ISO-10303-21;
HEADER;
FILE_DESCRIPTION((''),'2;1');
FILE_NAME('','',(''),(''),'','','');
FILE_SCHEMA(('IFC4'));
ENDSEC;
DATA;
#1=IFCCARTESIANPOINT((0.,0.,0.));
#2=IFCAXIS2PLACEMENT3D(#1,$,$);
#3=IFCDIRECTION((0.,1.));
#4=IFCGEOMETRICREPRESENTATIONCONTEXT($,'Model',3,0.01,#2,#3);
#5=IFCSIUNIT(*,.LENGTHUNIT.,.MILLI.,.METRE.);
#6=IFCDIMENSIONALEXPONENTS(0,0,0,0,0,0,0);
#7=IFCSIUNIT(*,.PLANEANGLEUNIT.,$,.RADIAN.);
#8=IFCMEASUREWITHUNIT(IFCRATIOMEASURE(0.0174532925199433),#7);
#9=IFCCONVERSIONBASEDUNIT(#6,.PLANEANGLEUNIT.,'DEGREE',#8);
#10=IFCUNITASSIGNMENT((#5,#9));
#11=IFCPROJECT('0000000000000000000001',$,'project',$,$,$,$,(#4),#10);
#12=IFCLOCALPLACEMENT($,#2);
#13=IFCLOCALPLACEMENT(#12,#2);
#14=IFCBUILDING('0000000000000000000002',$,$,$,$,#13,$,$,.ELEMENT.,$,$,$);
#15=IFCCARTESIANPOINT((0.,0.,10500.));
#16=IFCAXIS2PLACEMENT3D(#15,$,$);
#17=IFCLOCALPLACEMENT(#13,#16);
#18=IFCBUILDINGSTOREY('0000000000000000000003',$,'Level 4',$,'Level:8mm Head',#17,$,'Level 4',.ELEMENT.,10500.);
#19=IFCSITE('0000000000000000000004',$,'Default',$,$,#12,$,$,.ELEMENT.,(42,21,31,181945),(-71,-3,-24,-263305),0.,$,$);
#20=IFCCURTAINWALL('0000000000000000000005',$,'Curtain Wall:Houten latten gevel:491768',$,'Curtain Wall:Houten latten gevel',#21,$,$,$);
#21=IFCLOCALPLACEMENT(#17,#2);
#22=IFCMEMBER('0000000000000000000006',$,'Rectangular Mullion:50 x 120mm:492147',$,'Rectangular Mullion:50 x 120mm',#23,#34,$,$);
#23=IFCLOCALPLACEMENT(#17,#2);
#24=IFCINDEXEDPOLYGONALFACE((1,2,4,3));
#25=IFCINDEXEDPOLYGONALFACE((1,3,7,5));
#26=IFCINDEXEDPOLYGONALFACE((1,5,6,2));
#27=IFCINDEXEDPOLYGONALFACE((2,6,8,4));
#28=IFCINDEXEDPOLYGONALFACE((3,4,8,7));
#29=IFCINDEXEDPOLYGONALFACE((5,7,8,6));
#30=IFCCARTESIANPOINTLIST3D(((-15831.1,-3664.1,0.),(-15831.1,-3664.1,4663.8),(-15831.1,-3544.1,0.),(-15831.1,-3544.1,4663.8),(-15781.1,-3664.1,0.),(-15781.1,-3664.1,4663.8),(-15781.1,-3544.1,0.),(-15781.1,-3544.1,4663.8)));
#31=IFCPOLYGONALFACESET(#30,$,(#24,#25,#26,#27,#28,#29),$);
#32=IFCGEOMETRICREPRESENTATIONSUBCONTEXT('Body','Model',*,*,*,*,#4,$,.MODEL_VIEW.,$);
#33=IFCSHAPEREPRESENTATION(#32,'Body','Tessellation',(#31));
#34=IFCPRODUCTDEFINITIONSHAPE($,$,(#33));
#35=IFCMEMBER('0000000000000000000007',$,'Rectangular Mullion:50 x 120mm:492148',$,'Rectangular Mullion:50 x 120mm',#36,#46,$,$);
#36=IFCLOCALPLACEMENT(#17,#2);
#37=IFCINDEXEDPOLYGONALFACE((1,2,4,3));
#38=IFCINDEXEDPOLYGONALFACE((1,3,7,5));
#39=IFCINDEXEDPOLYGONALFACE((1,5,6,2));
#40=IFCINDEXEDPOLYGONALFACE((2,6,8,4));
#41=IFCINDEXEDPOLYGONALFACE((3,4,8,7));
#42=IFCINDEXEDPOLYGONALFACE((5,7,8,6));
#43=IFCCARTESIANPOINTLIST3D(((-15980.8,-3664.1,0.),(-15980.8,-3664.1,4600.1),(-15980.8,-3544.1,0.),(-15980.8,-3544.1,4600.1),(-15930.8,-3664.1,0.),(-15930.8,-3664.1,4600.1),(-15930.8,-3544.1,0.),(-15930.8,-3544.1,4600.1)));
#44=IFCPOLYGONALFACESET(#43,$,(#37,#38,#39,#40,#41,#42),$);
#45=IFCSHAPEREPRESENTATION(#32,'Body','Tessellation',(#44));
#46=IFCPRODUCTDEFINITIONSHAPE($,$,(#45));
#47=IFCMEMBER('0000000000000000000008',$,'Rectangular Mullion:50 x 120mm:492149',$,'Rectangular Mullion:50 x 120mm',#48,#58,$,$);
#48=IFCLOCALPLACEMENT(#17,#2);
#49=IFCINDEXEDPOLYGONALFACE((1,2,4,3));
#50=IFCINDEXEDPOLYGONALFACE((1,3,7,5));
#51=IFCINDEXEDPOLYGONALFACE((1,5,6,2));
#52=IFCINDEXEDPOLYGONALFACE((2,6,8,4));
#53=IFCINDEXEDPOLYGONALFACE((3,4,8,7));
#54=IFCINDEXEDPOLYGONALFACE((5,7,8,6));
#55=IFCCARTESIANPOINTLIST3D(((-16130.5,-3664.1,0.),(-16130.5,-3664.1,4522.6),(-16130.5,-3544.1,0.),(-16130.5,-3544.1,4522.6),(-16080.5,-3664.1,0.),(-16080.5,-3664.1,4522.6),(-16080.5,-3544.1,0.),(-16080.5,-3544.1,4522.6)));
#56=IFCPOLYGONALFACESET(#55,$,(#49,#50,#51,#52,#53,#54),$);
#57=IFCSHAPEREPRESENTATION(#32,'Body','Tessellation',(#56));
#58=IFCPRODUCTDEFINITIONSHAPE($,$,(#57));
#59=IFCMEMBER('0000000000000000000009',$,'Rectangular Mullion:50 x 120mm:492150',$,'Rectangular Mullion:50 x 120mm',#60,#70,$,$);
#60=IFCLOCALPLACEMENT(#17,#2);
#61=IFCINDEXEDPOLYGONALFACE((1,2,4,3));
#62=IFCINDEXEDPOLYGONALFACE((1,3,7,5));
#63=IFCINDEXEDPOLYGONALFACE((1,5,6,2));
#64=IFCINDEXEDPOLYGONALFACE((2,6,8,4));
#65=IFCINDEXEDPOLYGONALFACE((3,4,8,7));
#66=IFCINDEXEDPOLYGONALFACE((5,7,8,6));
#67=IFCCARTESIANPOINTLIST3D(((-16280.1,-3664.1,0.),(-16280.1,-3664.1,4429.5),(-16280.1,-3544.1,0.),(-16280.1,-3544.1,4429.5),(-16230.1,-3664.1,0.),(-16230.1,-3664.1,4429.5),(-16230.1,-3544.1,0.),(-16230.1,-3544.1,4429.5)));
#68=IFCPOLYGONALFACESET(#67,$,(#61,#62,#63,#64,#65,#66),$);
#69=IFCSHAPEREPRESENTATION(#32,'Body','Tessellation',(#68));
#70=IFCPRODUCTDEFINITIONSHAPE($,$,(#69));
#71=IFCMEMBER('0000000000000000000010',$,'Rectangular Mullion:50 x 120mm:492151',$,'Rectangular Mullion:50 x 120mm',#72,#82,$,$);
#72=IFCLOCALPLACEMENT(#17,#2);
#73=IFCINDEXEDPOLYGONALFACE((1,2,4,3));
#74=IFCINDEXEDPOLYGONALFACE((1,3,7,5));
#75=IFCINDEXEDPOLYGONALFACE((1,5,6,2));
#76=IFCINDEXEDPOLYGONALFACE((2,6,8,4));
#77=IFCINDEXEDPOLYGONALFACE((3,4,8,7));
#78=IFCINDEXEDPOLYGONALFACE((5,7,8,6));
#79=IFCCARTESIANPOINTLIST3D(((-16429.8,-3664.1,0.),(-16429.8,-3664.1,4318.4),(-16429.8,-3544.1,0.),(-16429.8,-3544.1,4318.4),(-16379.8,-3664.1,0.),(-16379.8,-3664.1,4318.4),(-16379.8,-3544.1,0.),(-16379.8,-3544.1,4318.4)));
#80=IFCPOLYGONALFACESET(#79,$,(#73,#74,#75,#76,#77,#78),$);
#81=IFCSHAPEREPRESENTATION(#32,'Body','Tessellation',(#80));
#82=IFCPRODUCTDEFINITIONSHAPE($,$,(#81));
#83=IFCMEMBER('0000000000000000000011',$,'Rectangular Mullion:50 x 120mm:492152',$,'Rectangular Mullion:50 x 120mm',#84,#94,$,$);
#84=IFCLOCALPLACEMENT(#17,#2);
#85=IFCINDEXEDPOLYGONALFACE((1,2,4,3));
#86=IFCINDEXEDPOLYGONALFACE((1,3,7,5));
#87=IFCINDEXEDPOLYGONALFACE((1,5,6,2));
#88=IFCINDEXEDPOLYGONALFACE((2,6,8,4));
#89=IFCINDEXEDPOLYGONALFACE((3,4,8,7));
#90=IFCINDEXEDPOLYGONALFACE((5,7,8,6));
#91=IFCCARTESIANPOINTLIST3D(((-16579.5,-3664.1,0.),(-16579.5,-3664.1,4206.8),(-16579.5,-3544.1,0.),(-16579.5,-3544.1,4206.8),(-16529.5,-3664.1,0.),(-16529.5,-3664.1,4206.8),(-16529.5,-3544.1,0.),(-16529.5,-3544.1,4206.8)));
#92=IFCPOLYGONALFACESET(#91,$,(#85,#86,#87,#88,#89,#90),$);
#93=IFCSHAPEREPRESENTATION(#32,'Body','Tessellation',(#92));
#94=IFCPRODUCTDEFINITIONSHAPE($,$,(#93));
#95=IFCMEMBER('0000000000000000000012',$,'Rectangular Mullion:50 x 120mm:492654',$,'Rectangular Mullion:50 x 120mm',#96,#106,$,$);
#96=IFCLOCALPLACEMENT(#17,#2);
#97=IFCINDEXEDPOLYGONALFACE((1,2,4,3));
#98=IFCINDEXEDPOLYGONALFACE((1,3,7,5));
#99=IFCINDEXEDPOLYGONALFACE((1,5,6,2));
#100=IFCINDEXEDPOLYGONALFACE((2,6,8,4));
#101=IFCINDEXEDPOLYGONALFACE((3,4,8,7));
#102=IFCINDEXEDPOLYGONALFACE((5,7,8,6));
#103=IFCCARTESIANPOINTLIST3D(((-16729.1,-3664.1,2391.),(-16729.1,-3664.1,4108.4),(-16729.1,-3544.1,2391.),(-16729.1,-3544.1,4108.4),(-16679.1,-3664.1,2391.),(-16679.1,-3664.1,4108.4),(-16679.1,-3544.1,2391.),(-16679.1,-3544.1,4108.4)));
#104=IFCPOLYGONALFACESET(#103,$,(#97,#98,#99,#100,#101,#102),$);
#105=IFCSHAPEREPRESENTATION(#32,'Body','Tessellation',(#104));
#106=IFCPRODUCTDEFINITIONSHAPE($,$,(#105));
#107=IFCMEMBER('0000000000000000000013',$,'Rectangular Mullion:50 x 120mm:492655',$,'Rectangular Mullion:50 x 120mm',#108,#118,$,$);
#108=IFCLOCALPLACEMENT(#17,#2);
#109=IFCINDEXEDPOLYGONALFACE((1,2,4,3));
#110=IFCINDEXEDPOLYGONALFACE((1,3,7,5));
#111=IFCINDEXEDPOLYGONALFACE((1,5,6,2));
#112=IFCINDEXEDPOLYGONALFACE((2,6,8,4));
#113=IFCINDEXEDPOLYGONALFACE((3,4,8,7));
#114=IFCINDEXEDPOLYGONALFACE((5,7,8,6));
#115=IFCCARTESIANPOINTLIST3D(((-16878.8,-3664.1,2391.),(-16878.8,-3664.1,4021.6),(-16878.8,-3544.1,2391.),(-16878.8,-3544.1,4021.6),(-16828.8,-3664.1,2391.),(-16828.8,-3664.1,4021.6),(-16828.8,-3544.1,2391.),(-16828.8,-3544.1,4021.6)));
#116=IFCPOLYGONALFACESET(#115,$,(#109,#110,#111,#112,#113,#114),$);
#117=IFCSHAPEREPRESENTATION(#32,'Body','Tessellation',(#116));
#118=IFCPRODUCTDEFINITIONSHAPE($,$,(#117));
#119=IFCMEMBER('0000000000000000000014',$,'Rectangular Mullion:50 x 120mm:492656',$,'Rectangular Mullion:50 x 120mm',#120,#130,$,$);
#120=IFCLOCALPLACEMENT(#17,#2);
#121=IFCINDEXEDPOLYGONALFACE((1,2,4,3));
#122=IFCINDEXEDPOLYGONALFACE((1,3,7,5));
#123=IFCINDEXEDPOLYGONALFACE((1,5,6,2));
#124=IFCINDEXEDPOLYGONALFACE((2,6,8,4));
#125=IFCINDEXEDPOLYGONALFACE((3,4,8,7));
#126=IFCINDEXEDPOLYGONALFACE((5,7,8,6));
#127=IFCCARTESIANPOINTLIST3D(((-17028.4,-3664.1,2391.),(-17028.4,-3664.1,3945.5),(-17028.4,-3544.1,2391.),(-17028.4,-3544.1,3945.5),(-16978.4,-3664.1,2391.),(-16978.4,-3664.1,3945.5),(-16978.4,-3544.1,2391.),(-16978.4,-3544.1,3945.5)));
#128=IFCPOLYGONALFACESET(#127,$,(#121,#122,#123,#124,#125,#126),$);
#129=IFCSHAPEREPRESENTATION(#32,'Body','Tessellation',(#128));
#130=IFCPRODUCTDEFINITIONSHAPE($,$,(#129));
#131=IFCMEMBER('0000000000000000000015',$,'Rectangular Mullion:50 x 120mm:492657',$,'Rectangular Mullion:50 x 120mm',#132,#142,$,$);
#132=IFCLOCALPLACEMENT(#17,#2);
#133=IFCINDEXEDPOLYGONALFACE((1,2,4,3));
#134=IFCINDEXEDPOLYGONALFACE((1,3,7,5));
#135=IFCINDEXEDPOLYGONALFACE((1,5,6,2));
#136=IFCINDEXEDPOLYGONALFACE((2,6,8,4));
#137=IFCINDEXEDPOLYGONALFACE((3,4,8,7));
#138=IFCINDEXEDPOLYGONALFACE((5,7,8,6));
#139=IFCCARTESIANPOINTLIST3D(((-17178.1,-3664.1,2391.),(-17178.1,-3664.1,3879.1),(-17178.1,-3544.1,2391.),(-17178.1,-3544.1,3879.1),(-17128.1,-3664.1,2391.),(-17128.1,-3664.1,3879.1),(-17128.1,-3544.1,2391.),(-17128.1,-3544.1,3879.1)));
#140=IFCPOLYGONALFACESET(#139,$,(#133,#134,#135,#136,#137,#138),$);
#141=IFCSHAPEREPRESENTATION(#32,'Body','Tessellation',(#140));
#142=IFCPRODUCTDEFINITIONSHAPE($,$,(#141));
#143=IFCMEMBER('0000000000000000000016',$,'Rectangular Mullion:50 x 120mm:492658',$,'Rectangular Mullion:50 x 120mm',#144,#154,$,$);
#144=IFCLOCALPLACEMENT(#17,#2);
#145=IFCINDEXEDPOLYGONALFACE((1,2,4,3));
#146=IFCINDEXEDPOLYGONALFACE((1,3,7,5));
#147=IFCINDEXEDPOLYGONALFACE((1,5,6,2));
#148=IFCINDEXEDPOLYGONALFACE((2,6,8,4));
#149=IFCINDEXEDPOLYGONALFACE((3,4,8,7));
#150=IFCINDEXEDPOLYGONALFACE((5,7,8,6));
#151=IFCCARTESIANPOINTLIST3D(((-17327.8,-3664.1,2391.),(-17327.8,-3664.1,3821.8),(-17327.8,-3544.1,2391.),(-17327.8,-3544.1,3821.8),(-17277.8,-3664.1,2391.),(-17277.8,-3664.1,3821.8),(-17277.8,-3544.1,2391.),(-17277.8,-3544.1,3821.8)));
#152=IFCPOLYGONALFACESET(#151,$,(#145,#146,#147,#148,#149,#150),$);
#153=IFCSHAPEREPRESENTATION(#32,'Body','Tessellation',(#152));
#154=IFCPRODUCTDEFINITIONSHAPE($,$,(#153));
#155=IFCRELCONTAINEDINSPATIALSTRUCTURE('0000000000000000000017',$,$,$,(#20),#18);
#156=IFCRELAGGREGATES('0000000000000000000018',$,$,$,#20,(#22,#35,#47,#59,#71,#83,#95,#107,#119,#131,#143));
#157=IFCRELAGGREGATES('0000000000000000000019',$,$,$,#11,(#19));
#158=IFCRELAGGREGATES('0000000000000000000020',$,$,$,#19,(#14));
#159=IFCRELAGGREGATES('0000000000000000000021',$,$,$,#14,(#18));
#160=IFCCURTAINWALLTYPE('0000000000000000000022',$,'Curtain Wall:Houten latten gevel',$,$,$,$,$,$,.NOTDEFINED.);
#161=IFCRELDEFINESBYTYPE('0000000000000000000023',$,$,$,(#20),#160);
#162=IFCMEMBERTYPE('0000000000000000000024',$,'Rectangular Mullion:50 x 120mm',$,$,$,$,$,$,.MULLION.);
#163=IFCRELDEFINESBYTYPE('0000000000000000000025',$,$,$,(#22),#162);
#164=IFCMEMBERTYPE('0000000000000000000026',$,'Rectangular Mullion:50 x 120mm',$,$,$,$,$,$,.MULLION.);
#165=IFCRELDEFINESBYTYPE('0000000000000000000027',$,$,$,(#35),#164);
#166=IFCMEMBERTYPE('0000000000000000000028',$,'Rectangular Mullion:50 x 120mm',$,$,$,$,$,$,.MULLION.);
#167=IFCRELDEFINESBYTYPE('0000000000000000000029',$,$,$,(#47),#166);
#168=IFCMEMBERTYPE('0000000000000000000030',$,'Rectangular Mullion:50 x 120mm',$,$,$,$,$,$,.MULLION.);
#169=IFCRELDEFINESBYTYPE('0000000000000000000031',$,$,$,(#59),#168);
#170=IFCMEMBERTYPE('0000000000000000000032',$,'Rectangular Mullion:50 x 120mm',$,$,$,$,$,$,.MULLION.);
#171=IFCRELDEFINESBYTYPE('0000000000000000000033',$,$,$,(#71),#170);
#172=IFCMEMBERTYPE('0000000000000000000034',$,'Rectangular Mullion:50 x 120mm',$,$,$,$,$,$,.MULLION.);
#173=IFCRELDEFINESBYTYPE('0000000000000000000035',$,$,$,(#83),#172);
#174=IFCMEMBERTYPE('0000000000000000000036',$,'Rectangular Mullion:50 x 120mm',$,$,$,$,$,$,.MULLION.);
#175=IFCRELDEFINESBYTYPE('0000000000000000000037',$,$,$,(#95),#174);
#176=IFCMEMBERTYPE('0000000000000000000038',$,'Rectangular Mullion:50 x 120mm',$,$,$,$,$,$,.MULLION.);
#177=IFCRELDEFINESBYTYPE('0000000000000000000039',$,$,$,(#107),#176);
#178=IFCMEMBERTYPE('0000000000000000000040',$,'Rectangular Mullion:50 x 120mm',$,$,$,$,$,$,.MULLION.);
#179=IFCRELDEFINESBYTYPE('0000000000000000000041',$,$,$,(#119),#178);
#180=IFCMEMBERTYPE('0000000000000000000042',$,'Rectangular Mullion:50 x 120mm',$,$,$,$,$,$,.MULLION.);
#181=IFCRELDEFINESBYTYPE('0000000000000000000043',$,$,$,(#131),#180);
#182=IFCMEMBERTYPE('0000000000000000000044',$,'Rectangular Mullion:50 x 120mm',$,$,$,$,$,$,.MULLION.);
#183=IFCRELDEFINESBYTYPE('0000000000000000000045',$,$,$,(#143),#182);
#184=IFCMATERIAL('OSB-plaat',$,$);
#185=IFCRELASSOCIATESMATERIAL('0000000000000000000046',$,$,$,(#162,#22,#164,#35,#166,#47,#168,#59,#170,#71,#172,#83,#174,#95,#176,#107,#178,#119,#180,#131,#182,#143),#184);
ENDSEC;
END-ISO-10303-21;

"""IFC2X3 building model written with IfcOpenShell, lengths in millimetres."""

from ifc_helpers import new_model, entity, si_unit, converted_unit, direction, frame, origin, origin_2d_with_axis, place, context, subcontext, project, spatial, rectangle, extrude, source, transform, mapped, material, type_object, type_shapes, element, aggregate, save


model = new_model("IFC2X3")

# Units and contexts
model_context = context("Model", 3, precision=0.01, world=origin(), true_north=direction((0.0, 1.0)))
body_context = subcontext(model_context, "Body", "Model", "MODEL_VIEW")
ifc_project = project(units=[si_unit("LENGTHUNIT", "METRE", prefix="MILLI"), converted_unit("PLANEANGLEUNIT", "DEGREE", entity("IfcRatioMeasure", 0.0174532925199433), si_unit("PLANEANGLEUNIT", "RADIAN"), dimensions=[0, 0, 0, 0, 0, 0, 0])], contexts=[model_context])

# Site, building, storey
site_placement = place(None, frame((0.0, 0.0, 0.0)))
site = spatial("IfcSite", under=ifc_project, at=site_placement, Name="Default", CompositionType="ELEMENT", RefLatitude=(42, 21, 31, 181945), RefLongitude=(-71, -3, -24, -263305), RefElevation=0.0)
building_placement = place(site_placement, origin())
building = spatial("IfcBuilding", under=site, at=building_placement, CompositionType="ELEMENT")
storey_placement = place(building_placement, frame((0.0, 0.0, 10500.0)))
storey = spatial("IfcBuildingStorey", under=building, at=storey_placement, Name="Level 4", ObjectType="Level:8mm Head", LongName="Level 4", CompositionType="ELEMENT", Elevation=10500.0)

# Curtain wall, members
curtain_wall_type = type_object("IfcCurtainWallType", Name="Curtain Wall:Houten latten gevel", PredefinedType="NOTDEFINED")
curtain_wall_placement = place(storey_placement, frame((0.0, 0.0, -10500.0)))
curtain_wall = element("IfcCurtainWall", 1, at=curtain_wall_placement, inside=storey, type_object=curtain_wall_type, Name="Curtain Wall:Houten latten gevel:491768", ObjectType="Curtain Wall:Houten latten gevel")
ifc_material_1 = material(Name="OSB-plaat")
placement = place(building_placement, frame((0.0, 0.0, 7500.0)))
member_type_1 = type_object("IfcMemberType", Name="Rectangular Mullion:50 x 120mm", PredefinedType="MULLION", material=ifc_material_1)
shared_shape_1 = source(origin(), body_context, "Body", "SweptSolid", [
    extrude(rectangle(XDim=120.0, YDim=50.0, at=origin_2d_with_axis()), frame((0.0, 0.0, -4663.8), z_axis=(0.0, 0.0, 1.0), x_axis=(0.0, -1.0, 0.0)), (0.0, 0.0, 1.0), 4663.8),
])
type_shapes(member_type_1, [shared_shape_1])
member_1_placement = place(placement, frame((-15806.1, -3604.1, 3000.0), z_axis=(0.0, 0.0, -1.0), x_axis=(-1.0, 0.0, 0.0)))
member_1 = element("IfcMember", 2, at=member_1_placement, type_object=member_type_1, material=ifc_material_1, Name="Rectangular Mullion:50 x 120mm:492147", ObjectType="Rectangular Mullion:50 x 120mm", context=body_context, shape_type="MappedRepresentation", body=[
    mapped(shared_shape_1, transform((0.0, 0.0, 0.0), scale=1.0)),
])
member_type_2 = type_object("IfcMemberType", Name="Rectangular Mullion:50 x 120mm", PredefinedType="MULLION", material=ifc_material_1)
shared_shape_2 = source(origin(), body_context, "Body", "SweptSolid", [
    extrude(rectangle(XDim=120.0, YDim=50.0, at=origin_2d_with_axis()), frame((0.0, 0.0, -4600.1), z_axis=(0.0, 0.0, 1.0), x_axis=(0.0, -1.0, 0.0)), (0.0, 0.0, 1.0), 4600.1),
])
type_shapes(member_type_2, [shared_shape_2])
member_2_placement = place(placement, frame((-15955.8, -3604.1, 3000.0), z_axis=(0.0, 0.0, -1.0), x_axis=(-1.0, 0.0, 0.0)))
member_2 = element("IfcMember", 3, at=member_2_placement, type_object=member_type_2, material=ifc_material_1, Name="Rectangular Mullion:50 x 120mm:492148", ObjectType="Rectangular Mullion:50 x 120mm", context=body_context, shape_type="MappedRepresentation", body=[
    mapped(shared_shape_2, transform((0.0, 0.0, 0.0), scale=1.0)),
])
member_type_3 = type_object("IfcMemberType", Name="Rectangular Mullion:50 x 120mm", PredefinedType="MULLION", material=ifc_material_1)
shared_shape_3 = source(origin(), body_context, "Body", "SweptSolid", [
    extrude(rectangle(XDim=120.0, YDim=50.0, at=origin_2d_with_axis()), frame((0.0, 0.0, -4522.6), z_axis=(0.0, 0.0, 1.0), x_axis=(0.0, -1.0, 0.0)), (0.0, 0.0, 1.0), 4522.6),
])
type_shapes(member_type_3, [shared_shape_3])
member_3_placement = place(placement, frame((-16105.5, -3604.1, 3000.0), z_axis=(0.0, 0.0, -1.0), x_axis=(-1.0, 0.0, 0.0)))
member_3 = element("IfcMember", 4, at=member_3_placement, type_object=member_type_3, material=ifc_material_1, Name="Rectangular Mullion:50 x 120mm:492149", ObjectType="Rectangular Mullion:50 x 120mm", context=body_context, shape_type="MappedRepresentation", body=[
    mapped(shared_shape_3, transform((0.0, 0.0, 0.0), scale=1.0)),
])
member_type_4 = type_object("IfcMemberType", Name="Rectangular Mullion:50 x 120mm", PredefinedType="MULLION", material=ifc_material_1)
shared_shape_4 = source(origin(), body_context, "Body", "SweptSolid", [
    extrude(rectangle(XDim=120.0, YDim=50.0, at=origin_2d_with_axis()), frame((0.0, 0.0, -4429.5), z_axis=(0.0, 0.0, 1.0), x_axis=(0.0, -1.0, 0.0)), (0.0, 0.0, 1.0), 4429.5),
])
type_shapes(member_type_4, [shared_shape_4])
member_4_placement = place(placement, frame((-16255.1, -3604.1, 3000.0), z_axis=(0.0, 0.0, -1.0), x_axis=(-1.0, 0.0, 0.0)))
member_4 = element("IfcMember", 5, at=member_4_placement, type_object=member_type_4, material=ifc_material_1, Name="Rectangular Mullion:50 x 120mm:492150", ObjectType="Rectangular Mullion:50 x 120mm", context=body_context, shape_type="MappedRepresentation", body=[
    mapped(shared_shape_4, transform((0.0, 0.0, 0.0), scale=1.0)),
])
member_type_5 = type_object("IfcMemberType", Name="Rectangular Mullion:50 x 120mm", PredefinedType="MULLION", material=ifc_material_1)
shared_shape_5 = source(origin(), body_context, "Body", "SweptSolid", [
    extrude(rectangle(XDim=120.0, YDim=50.0, at=origin_2d_with_axis()), frame((0.0, 0.0, -4318.4), z_axis=(0.0, 0.0, 1.0), x_axis=(0.0, -1.0, 0.0)), (0.0, 0.0, 1.0), 4318.4),
])
type_shapes(member_type_5, [shared_shape_5])
member_5_placement = place(placement, frame((-16404.8, -3604.1, 3000.0), z_axis=(0.0, 0.0, -1.0), x_axis=(-1.0, 0.0, 0.0)))
member_5 = element("IfcMember", 6, at=member_5_placement, type_object=member_type_5, material=ifc_material_1, Name="Rectangular Mullion:50 x 120mm:492151", ObjectType="Rectangular Mullion:50 x 120mm", context=body_context, shape_type="MappedRepresentation", body=[
    mapped(shared_shape_5, transform((0.0, 0.0, 0.0), scale=1.0)),
])
member_type_6 = type_object("IfcMemberType", Name="Rectangular Mullion:50 x 120mm", PredefinedType="MULLION", material=ifc_material_1)
shared_shape_6 = source(origin(), body_context, "Body", "SweptSolid", [
    extrude(rectangle(XDim=120.0, YDim=50.0, at=origin_2d_with_axis()), frame((0.0, 0.0, -4206.8), z_axis=(0.0, 0.0, 1.0), x_axis=(0.0, -1.0, 0.0)), (0.0, 0.0, 1.0), 4206.8),
])
type_shapes(member_type_6, [shared_shape_6])
member_6_placement = place(placement, frame((-16554.5, -3604.1, 3000.0), z_axis=(0.0, 0.0, -1.0), x_axis=(-1.0, 0.0, 0.0)))
member_6 = element("IfcMember", 7, at=member_6_placement, type_object=member_type_6, material=ifc_material_1, Name="Rectangular Mullion:50 x 120mm:492152", ObjectType="Rectangular Mullion:50 x 120mm", context=body_context, shape_type="MappedRepresentation", body=[
    mapped(shared_shape_6, transform((0.0, 0.0, 0.0), scale=1.0)),
])
member_type_7 = type_object("IfcMemberType", Name="Rectangular Mullion:50 x 120mm", PredefinedType="MULLION", material=ifc_material_1)
shared_shape_7 = source(origin(), body_context, "Body", "SweptSolid", [
    extrude(rectangle(XDim=120.0, YDim=50.0, at=origin_2d_with_axis()), frame((0.0, 0.0, -1717.4), z_axis=(0.0, 0.0, 1.0), x_axis=(0.0, -1.0, 0.0)), (0.0, 0.0, 1.0), 1717.4),
])
type_shapes(member_type_7, [shared_shape_7])
member_7_placement = place(storey_placement, frame((-16704.1, -3604.1, 2391.0), z_axis=(0.0, 0.0, -1.0), x_axis=(-1.0, 0.0, 0.0)))
member_7 = element("IfcMember", 8, at=member_7_placement, type_object=member_type_7, material=ifc_material_1, Name="Rectangular Mullion:50 x 120mm:492654", ObjectType="Rectangular Mullion:50 x 120mm", context=body_context, shape_type="MappedRepresentation", body=[
    mapped(shared_shape_7, transform((0.0, 0.0, 0.0), scale=1.0)),
])
member_type_8 = type_object("IfcMemberType", Name="Rectangular Mullion:50 x 120mm", PredefinedType="MULLION", material=ifc_material_1)
shared_shape_8 = source(origin(), body_context, "Body", "SweptSolid", [
    extrude(rectangle(XDim=120.0, YDim=50.0, at=origin_2d_with_axis()), frame((0.0, 0.0, -1630.6), z_axis=(0.0, 0.0, 1.0), x_axis=(0.0, -1.0, 0.0)), (0.0, 0.0, 1.0), 1630.6),
])
type_shapes(member_type_8, [shared_shape_8])
member_8_placement = place(storey_placement, frame((-16853.8, -3604.1, 2391.0), z_axis=(0.0, 0.0, -1.0), x_axis=(-1.0, 0.0, 0.0)))
member_8 = element("IfcMember", 9, at=member_8_placement, type_object=member_type_8, material=ifc_material_1, Name="Rectangular Mullion:50 x 120mm:492655", ObjectType="Rectangular Mullion:50 x 120mm", context=body_context, shape_type="MappedRepresentation", body=[
    mapped(shared_shape_8, transform((0.0, 0.0, 0.0), scale=1.0)),
])
member_type_9 = type_object("IfcMemberType", Name="Rectangular Mullion:50 x 120mm", PredefinedType="MULLION", material=ifc_material_1)
shared_shape_9 = source(origin(), body_context, "Body", "SweptSolid", [
    extrude(rectangle(XDim=120.0, YDim=50.0, at=origin_2d_with_axis()), frame((0.0, 0.0, -1554.5), z_axis=(0.0, 0.0, 1.0), x_axis=(0.0, -1.0, 0.0)), (0.0, 0.0, 1.0), 1554.5),
])
type_shapes(member_type_9, [shared_shape_9])
member_9_placement = place(storey_placement, frame((-17003.4, -3604.1, 2391.0), z_axis=(0.0, 0.0, -1.0), x_axis=(-1.0, 0.0, 0.0)))
member_9 = element("IfcMember", 10, at=member_9_placement, type_object=member_type_9, material=ifc_material_1, Name="Rectangular Mullion:50 x 120mm:492656", ObjectType="Rectangular Mullion:50 x 120mm", context=body_context, shape_type="MappedRepresentation", body=[
    mapped(shared_shape_9, transform((0.0, 0.0, 0.0), scale=1.0)),
])
member_type_10 = type_object("IfcMemberType", Name="Rectangular Mullion:50 x 120mm", PredefinedType="MULLION", material=ifc_material_1)
shared_shape_10 = source(origin(), body_context, "Body", "SweptSolid", [
    extrude(rectangle(XDim=120.0, YDim=50.0, at=origin_2d_with_axis()), frame((0.0, 0.0, -1488.1), z_axis=(0.0, 0.0, 1.0), x_axis=(0.0, -1.0, 0.0)), (0.0, 0.0, 1.0), 1488.1),
])
type_shapes(member_type_10, [shared_shape_10])
member_10_placement = place(storey_placement, frame((-17153.1, -3604.1, 2391.0), z_axis=(0.0, 0.0, -1.0), x_axis=(-1.0, 0.0, 0.0)))
member_10 = element("IfcMember", 11, at=member_10_placement, type_object=member_type_10, material=ifc_material_1, Name="Rectangular Mullion:50 x 120mm:492657", ObjectType="Rectangular Mullion:50 x 120mm", context=body_context, shape_type="MappedRepresentation", body=[
    mapped(shared_shape_10, transform((0.0, 0.0, 0.0), scale=1.0)),
])
member_type_11 = type_object("IfcMemberType", Name="Rectangular Mullion:50 x 120mm", PredefinedType="MULLION", material=ifc_material_1)
shared_shape_11 = source(origin(), body_context, "Body", "SweptSolid", [
    extrude(rectangle(XDim=120.0, YDim=50.0, at=origin_2d_with_axis()), frame((0.0, 0.0, -1430.8), z_axis=(0.0, 0.0, 1.0), x_axis=(0.0, -1.0, 0.0)), (0.0, 0.0, 1.0), 1430.8),
])
type_shapes(member_type_11, [shared_shape_11])
member_11_placement = place(storey_placement, frame((-17302.8, -3604.1, 2391.0), z_axis=(0.0, 0.0, -1.0), x_axis=(-1.0, 0.0, 0.0)))
member_11 = element("IfcMember", 12, at=member_11_placement, type_object=member_type_11, material=ifc_material_1, Name="Rectangular Mullion:50 x 120mm:492658", ObjectType="Rectangular Mullion:50 x 120mm", context=body_context, shape_type="MappedRepresentation", body=[
    mapped(shared_shape_11, transform((0.0, 0.0, 0.0), scale=1.0)),
])
aggregate(curtain_wall, [member_1, member_2, member_3, member_4, member_5, member_6, member_7, member_8, member_9, member_10, member_11])

save(model, "model.ifc")
